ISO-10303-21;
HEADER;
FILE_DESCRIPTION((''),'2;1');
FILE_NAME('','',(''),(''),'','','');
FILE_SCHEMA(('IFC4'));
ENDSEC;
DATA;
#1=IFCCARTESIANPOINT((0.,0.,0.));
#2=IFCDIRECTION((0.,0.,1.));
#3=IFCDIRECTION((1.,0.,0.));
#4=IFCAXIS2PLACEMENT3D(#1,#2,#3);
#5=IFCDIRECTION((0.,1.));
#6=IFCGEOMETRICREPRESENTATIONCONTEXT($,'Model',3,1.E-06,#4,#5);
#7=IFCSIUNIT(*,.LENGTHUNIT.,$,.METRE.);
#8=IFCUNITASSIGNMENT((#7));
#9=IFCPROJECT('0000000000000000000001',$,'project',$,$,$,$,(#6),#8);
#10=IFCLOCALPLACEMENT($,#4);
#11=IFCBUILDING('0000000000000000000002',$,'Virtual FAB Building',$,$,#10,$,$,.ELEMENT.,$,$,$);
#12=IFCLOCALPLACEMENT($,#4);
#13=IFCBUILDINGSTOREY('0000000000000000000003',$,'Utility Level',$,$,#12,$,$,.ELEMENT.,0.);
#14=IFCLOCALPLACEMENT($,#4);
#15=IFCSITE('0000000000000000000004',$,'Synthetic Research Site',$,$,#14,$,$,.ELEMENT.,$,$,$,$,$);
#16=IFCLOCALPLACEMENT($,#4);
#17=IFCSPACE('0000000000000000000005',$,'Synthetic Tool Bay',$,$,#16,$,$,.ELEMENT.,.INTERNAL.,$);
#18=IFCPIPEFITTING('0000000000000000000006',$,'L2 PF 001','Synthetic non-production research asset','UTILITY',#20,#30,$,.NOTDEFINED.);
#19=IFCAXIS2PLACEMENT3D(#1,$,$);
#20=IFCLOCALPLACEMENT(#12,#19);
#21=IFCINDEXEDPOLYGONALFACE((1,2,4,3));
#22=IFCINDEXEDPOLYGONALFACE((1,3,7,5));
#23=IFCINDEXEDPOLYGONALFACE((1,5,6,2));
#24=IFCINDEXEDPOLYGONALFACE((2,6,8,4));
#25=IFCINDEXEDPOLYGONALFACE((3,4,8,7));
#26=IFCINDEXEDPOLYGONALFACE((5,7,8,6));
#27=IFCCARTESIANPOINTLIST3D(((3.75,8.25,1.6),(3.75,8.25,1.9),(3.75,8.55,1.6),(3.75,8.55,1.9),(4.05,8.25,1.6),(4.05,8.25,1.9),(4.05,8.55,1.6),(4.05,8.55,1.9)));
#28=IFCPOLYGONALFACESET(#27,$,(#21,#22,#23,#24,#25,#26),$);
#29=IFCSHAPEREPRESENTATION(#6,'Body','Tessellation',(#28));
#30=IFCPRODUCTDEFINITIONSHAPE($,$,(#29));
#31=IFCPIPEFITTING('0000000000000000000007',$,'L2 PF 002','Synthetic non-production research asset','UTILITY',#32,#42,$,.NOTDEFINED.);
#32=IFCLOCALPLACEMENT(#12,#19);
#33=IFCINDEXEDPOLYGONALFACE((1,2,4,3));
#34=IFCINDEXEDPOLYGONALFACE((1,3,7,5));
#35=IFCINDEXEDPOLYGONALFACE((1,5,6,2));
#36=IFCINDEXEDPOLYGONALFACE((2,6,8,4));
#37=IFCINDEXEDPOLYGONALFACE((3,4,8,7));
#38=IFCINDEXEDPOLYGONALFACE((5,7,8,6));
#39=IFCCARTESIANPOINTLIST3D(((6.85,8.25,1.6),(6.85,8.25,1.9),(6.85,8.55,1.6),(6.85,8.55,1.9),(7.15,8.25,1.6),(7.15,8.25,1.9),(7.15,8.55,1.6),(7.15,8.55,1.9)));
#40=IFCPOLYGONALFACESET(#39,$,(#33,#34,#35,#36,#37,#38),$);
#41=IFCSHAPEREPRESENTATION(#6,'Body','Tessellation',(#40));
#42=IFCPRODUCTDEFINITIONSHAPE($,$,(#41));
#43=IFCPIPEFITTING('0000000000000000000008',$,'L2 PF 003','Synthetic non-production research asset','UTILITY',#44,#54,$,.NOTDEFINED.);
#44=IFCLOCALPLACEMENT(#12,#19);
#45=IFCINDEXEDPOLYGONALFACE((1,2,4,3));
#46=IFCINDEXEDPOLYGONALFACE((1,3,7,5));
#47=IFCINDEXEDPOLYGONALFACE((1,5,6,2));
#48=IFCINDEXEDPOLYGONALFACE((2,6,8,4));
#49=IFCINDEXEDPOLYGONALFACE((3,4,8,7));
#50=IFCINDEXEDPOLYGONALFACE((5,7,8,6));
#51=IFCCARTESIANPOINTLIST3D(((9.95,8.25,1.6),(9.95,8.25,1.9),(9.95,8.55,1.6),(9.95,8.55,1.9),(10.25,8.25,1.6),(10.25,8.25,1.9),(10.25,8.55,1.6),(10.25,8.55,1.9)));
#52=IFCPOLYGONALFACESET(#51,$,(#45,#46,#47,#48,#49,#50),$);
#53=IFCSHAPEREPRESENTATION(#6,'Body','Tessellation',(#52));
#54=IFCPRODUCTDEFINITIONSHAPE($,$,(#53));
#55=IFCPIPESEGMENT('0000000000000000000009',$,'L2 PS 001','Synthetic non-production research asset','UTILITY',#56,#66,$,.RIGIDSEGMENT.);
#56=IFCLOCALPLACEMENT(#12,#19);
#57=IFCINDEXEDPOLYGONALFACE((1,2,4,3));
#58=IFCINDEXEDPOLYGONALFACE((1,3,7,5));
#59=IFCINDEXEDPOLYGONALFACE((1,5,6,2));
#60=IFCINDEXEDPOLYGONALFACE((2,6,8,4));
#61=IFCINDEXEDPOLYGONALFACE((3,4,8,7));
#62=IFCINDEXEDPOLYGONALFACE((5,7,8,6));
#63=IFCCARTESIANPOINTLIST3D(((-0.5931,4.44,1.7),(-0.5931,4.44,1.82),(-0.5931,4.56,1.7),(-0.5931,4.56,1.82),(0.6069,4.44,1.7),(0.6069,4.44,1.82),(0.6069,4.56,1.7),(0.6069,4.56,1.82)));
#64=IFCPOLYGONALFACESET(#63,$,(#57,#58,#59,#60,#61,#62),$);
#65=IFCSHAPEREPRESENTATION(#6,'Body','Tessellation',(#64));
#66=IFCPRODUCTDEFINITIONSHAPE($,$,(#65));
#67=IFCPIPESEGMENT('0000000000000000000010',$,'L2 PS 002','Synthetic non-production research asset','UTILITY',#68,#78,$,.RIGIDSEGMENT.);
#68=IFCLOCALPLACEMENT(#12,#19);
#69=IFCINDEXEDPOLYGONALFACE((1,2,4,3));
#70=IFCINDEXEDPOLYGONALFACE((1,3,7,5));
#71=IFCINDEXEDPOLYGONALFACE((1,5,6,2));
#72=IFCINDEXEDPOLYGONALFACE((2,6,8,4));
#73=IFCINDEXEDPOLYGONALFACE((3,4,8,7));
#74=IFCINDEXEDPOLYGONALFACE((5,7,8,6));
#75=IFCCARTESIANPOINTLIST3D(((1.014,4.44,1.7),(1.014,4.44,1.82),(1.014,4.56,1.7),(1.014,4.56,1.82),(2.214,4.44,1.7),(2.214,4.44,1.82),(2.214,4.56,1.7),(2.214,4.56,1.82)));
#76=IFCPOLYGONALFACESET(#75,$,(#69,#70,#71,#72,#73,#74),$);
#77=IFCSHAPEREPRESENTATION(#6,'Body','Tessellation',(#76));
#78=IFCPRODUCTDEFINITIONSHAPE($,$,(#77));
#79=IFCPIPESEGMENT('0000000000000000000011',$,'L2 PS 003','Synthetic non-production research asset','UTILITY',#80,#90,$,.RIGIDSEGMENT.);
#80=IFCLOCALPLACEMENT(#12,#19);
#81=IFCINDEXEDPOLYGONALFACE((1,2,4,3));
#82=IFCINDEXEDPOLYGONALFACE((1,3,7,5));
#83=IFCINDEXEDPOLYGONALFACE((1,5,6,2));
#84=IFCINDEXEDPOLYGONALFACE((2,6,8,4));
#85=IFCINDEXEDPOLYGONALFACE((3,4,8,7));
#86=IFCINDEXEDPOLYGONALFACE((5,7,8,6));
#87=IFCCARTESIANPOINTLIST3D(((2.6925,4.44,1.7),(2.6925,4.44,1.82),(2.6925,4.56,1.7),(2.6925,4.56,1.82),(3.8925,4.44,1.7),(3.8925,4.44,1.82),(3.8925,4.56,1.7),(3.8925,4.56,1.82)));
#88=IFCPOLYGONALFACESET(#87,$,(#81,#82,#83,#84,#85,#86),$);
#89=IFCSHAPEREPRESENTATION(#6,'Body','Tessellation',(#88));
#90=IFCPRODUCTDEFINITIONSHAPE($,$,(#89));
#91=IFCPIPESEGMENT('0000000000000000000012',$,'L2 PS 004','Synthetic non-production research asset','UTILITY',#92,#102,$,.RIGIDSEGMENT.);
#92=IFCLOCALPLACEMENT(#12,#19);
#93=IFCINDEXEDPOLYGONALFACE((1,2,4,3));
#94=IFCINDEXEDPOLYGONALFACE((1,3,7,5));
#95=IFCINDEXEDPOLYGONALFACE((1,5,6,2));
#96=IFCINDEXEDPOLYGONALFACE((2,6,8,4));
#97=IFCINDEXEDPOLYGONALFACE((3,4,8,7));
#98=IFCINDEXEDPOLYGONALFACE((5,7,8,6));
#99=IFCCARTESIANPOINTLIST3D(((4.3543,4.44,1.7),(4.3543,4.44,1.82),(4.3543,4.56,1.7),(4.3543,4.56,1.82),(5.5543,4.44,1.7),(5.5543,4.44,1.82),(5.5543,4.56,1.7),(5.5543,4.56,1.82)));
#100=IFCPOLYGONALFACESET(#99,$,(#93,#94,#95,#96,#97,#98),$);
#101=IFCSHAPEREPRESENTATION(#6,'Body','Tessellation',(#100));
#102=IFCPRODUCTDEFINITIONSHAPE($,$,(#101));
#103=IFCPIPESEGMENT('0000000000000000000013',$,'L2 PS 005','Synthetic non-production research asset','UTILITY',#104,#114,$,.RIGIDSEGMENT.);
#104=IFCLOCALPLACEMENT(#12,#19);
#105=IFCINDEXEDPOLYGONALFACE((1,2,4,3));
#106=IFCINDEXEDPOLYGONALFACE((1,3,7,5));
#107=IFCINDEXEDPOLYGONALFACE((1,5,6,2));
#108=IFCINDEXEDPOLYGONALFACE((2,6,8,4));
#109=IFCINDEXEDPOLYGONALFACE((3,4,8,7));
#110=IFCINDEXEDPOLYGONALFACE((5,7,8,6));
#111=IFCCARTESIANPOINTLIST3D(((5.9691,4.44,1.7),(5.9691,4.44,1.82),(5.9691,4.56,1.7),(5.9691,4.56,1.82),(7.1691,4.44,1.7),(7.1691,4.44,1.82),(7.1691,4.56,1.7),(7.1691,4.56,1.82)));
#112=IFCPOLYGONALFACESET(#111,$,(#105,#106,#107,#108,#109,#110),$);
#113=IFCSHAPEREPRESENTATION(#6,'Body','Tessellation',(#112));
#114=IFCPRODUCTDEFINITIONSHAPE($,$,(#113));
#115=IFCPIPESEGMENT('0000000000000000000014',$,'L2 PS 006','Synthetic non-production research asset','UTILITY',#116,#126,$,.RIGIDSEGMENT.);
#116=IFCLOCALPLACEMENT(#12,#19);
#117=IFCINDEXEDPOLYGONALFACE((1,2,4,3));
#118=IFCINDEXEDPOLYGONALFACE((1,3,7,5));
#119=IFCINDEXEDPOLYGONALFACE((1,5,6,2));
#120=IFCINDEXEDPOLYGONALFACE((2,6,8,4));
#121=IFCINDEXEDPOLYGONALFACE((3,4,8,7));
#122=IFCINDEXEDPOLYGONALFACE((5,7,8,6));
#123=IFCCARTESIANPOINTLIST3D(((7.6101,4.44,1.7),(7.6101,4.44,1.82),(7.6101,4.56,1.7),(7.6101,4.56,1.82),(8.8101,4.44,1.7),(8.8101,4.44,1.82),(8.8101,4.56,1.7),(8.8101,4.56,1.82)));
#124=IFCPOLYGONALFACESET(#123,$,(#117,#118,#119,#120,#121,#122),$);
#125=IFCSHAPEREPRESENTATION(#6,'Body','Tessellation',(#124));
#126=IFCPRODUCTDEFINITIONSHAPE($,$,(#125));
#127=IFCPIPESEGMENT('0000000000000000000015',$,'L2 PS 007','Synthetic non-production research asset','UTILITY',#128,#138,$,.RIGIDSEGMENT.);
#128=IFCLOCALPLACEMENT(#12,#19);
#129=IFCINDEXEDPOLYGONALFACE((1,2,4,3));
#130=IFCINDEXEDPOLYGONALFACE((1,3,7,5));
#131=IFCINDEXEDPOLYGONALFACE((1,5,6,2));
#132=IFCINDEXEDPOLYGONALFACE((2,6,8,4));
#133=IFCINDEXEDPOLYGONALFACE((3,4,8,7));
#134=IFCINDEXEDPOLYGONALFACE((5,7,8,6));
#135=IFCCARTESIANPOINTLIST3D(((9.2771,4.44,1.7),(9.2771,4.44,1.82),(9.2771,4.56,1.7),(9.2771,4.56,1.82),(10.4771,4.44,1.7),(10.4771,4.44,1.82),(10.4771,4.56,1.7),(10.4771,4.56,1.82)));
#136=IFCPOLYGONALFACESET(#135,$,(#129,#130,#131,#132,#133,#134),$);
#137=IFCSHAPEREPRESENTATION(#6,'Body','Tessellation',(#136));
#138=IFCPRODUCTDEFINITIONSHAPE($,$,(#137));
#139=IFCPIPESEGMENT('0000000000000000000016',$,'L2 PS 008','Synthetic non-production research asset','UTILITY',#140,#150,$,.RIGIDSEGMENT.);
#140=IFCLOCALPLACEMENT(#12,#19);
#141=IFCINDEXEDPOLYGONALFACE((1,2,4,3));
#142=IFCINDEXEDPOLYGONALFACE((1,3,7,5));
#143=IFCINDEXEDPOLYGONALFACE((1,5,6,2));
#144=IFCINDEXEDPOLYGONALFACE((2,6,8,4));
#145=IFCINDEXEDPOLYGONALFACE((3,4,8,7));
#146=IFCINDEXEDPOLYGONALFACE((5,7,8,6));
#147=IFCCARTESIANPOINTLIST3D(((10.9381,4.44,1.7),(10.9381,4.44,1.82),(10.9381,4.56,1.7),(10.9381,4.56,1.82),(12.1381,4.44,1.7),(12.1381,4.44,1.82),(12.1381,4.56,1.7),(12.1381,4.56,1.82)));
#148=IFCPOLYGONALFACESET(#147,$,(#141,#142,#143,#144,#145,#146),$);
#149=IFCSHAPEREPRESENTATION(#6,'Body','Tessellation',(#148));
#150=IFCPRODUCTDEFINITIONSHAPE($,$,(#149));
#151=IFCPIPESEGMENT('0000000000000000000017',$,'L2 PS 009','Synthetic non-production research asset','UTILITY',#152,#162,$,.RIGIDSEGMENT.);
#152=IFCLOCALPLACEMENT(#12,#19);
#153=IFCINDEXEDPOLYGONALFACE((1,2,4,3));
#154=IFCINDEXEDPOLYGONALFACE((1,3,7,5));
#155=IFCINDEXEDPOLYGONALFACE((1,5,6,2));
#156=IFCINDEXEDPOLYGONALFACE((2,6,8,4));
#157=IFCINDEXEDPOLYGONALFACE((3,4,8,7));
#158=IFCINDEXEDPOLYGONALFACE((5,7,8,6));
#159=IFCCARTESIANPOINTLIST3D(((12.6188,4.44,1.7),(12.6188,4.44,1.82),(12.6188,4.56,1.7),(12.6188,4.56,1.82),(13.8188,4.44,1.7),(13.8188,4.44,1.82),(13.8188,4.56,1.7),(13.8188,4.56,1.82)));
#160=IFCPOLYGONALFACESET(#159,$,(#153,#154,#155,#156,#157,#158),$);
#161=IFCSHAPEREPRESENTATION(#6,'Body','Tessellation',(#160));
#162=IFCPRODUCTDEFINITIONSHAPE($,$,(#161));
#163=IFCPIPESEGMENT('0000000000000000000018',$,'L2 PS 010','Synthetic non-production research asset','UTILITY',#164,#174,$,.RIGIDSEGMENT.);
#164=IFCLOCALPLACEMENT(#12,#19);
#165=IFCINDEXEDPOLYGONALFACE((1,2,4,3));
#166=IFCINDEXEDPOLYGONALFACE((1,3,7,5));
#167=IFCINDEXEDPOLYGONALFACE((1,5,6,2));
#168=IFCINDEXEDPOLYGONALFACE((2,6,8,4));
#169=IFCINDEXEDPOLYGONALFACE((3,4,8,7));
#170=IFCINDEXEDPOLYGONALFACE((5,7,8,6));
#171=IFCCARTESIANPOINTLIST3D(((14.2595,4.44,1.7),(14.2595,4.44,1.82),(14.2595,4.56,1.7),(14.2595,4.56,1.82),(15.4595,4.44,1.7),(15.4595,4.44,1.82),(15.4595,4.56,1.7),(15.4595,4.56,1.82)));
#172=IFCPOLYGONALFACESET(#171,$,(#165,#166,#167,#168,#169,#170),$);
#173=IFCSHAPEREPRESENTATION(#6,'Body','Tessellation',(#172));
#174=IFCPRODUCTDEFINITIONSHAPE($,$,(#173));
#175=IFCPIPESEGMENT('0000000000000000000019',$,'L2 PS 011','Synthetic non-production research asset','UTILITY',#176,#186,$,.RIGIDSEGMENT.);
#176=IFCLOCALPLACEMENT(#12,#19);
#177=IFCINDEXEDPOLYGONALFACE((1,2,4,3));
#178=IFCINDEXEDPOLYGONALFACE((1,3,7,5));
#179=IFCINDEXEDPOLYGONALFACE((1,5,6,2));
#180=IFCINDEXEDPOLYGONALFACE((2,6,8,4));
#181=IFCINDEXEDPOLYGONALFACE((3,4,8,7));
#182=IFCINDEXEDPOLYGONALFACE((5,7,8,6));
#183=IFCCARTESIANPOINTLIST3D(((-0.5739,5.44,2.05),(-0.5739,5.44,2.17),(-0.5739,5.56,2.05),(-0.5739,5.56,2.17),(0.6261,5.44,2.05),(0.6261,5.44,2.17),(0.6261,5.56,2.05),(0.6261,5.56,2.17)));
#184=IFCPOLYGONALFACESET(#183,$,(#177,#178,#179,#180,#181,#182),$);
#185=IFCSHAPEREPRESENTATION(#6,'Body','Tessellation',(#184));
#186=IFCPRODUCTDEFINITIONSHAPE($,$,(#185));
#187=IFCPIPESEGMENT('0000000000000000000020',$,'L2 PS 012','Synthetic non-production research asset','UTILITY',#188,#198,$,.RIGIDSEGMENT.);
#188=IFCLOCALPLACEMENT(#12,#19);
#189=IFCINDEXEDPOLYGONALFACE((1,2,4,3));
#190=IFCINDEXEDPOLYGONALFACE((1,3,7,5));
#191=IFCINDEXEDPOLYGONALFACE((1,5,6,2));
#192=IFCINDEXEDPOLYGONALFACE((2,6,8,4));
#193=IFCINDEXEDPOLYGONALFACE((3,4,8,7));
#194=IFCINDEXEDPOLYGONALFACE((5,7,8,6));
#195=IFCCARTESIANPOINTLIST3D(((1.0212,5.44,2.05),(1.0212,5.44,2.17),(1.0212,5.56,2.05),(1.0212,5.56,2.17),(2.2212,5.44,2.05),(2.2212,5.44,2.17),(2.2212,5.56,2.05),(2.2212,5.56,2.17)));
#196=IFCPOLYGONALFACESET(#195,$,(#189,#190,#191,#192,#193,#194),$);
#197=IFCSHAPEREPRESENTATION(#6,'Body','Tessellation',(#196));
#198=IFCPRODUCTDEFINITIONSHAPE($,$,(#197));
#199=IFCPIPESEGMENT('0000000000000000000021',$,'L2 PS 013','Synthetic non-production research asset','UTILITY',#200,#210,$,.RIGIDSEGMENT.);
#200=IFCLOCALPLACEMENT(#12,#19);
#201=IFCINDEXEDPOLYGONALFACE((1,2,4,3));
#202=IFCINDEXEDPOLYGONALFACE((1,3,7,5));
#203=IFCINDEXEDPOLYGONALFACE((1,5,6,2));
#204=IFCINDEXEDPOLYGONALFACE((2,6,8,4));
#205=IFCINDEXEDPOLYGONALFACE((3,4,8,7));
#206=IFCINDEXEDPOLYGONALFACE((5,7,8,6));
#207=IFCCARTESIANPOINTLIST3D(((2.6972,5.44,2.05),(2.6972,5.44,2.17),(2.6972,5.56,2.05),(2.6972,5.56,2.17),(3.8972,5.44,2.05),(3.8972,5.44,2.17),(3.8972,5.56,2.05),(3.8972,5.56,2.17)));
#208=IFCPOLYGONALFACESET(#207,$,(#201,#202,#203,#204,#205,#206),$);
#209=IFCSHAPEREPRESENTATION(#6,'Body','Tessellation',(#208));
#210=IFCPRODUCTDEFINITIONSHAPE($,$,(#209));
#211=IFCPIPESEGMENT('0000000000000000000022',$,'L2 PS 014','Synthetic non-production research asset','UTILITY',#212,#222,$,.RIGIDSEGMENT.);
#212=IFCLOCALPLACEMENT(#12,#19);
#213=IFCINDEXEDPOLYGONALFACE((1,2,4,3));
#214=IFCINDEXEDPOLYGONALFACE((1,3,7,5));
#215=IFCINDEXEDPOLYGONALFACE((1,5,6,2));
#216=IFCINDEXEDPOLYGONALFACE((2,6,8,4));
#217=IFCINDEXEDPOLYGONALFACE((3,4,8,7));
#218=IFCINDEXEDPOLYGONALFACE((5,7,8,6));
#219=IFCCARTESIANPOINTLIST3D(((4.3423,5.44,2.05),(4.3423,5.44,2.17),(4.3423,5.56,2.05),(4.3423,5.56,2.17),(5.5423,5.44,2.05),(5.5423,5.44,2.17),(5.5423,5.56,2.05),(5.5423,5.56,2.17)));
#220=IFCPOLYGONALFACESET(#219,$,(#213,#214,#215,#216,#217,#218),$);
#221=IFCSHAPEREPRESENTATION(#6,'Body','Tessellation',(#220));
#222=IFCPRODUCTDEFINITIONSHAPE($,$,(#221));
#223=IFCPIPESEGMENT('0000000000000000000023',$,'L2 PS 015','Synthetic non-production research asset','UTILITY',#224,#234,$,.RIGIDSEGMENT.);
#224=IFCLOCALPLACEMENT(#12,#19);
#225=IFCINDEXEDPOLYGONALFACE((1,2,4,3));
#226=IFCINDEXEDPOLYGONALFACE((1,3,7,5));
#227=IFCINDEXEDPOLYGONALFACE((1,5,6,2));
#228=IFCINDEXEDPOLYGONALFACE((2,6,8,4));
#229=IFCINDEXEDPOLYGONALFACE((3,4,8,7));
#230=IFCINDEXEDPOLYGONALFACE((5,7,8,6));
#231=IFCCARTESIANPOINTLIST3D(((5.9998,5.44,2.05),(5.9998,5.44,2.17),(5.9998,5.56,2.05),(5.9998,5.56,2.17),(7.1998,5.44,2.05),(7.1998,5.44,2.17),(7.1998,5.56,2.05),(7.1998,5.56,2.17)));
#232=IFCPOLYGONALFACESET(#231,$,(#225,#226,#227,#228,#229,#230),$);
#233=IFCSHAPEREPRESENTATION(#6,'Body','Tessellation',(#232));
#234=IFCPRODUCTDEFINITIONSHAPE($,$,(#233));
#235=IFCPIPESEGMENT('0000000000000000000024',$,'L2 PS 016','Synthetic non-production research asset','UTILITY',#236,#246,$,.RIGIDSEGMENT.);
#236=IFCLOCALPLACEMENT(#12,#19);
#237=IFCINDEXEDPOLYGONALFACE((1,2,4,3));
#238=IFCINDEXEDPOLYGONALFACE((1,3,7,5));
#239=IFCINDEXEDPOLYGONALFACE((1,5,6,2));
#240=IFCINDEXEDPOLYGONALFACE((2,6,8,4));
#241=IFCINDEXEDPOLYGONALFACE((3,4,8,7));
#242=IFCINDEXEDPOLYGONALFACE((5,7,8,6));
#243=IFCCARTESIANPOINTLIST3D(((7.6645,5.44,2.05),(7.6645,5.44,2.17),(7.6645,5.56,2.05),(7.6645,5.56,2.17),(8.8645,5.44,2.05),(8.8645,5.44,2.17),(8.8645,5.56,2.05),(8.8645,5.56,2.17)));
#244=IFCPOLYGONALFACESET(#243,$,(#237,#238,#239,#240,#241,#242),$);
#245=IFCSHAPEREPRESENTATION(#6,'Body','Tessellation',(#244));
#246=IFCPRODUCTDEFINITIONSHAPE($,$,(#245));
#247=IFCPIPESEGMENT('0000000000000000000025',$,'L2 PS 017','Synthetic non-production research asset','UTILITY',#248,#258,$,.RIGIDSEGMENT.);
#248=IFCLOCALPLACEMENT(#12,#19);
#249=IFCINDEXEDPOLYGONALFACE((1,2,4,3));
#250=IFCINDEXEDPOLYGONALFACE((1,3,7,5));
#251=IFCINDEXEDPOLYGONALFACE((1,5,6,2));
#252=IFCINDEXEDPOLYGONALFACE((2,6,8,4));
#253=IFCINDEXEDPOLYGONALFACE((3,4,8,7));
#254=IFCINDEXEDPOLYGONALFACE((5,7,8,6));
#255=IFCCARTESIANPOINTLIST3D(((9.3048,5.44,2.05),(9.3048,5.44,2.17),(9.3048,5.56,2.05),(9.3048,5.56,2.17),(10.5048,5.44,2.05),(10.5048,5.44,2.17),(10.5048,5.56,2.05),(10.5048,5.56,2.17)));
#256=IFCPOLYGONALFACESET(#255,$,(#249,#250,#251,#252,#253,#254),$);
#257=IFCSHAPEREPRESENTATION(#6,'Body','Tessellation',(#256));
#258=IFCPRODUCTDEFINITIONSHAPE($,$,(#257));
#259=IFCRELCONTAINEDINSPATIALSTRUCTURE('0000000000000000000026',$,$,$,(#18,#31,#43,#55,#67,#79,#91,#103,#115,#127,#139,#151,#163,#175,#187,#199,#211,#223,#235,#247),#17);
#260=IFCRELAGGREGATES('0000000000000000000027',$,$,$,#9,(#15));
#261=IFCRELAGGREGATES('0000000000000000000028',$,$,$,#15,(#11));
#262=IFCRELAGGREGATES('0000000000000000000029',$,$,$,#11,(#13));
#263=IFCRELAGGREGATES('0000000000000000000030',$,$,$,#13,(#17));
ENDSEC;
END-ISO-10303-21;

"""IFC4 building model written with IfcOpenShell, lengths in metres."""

from ifc_helpers import new_model, si_unit, direction, frame, origin_with_axes, origin_2d_with_axis, place, context, project, spatial, rectangle, extrude, element, save


model = new_model("IFC4")

# Units and contexts
model_context = context("Model", 3, precision=1e-06, world=origin_with_axes(), true_north=direction((0.0, 1.0)))
ifc_project = project(units=[si_unit("LENGTHUNIT", "METRE")], contexts=[model_context])

# Site, building, storey, space
site_placement = place(None, origin_with_axes())
site = spatial("IfcSite", under=ifc_project, at=site_placement, Name="Synthetic Research Site", CompositionType="ELEMENT")
building_placement = place(None, origin_with_axes())
building = spatial("IfcBuilding", under=site, at=building_placement, Name="Virtual FAB Building", CompositionType="ELEMENT")
storey_placement = place(None, origin_with_axes())
storey = spatial("IfcBuildingStorey", under=building, at=storey_placement, Name="Utility Level", CompositionType="ELEMENT", Elevation=0.0)
space_placement = place(None, origin_with_axes())
space = spatial("IfcSpace", under=storey, at=space_placement, Name="Synthetic Tool Bay", CompositionType="ELEMENT", PredefinedType="INTERNAL")

# Pipe fittings
for number, where, z_axis, x_axis, name in (
    (1, (3.9, 8.4, 1.6), (0.0, 0.0, 1.0), (1.0, 0.0, 0.0), "L2 PF 001"),
    (2, (7.0, 8.4, 1.6), (0.0, 0.0, 1.0), (1.0, 0.0, 0.0), "L2 PF 002"),
    (3, (10.1, 8.4, 1.6), (0.0, 0.0, 1.0), (1.0, 0.0, 0.0), "L2 PF 003"),
):
    element("IfcPipeFitting", number, at=place(None, frame(where, z_axis=z_axis, x_axis=x_axis)), inside=space, Name=name, Description="Synthetic non-production research asset", ObjectType="UTILITY", PredefinedType="NOTDEFINED", context=model_context, shape_type="SweptSolid", body=[
        extrude(rectangle(XDim=0.3, YDim=0.3, at=origin_2d_with_axis()), origin_with_axes(), (0.0, 0.0, 1.0), 0.3),
    ])

# Pipe segments
for number, where, z_axis, x_axis, name in (
    (4, (0.0069, 4.5, 1.7), (0.0, 0.0, 1.0), (1.0, 0.0, 0.0), "L2 PS 001"),
    (5, (1.614, 4.5, 1.7), (0.0, 0.0, 1.0), (1.0, 0.0, 0.0), "L2 PS 002"),
    (6, (3.2925, 4.5, 1.7), (0.0, 0.0, 1.0), (1.0, 0.0, 0.0), "L2 PS 003"),
    (7, (4.9543, 4.5, 1.7), (0.0, 0.0, 1.0), (1.0, 0.0, 0.0), "L2 PS 004"),
    (8, (6.5691, 4.5, 1.7), (0.0, 0.0, 1.0), (1.0, 0.0, 0.0), "L2 PS 005"),
    (9, (8.2101, 4.5, 1.7), (0.0, 0.0, 1.0), (1.0, 0.0, 0.0), "L2 PS 006"),
    (10, (9.8771, 4.5, 1.7), (0.0, 0.0, 1.0), (1.0, 0.0, 0.0), "L2 PS 007"),
    (11, (11.5381, 4.5, 1.7), (0.0, 0.0, 1.0), (1.0, 0.0, 0.0), "L2 PS 008"),
    (12, (13.2188, 4.5, 1.7), (0.0, 0.0, 1.0), (1.0, 0.0, 0.0), "L2 PS 009"),
    (13, (14.8595, 4.5, 1.7), (0.0, 0.0, 1.0), (1.0, 0.0, 0.0), "L2 PS 010"),
    (14, (0.0261, 5.5, 2.05), (0.0, 0.0, 1.0), (1.0, 0.0, 0.0), "L2 PS 011"),
    (15, (1.6212, 5.5, 2.05), (0.0, 0.0, 1.0), (1.0, 0.0, 0.0), "L2 PS 012"),
    (16, (3.2972, 5.5, 2.05), (0.0, 0.0, 1.0), (1.0, 0.0, 0.0), "L2 PS 013"),
    (17, (4.9423, 5.5, 2.05), (0.0, 0.0, 1.0), (1.0, 0.0, 0.0), "L2 PS 014"),
    (18, (6.5998, 5.5, 2.05), (0.0, 0.0, 1.0), (1.0, 0.0, 0.0), "L2 PS 015"),
    (19, (8.2645, 5.5, 2.05), (0.0, 0.0, 1.0), (1.0, 0.0, 0.0), "L2 PS 016"),
    (20, (9.9048, 5.5, 2.05), (0.0, 0.0, 1.0), (1.0, 0.0, 0.0), "L2 PS 017"),
):
    element("IfcPipeSegment", number, at=place(None, frame(where, z_axis=z_axis, x_axis=x_axis)), inside=space, Name=name, Description="Synthetic non-production research asset", ObjectType="UTILITY", PredefinedType="RIGIDSEGMENT", context=model_context, shape_type="SweptSolid", body=[
        extrude(rectangle(XDim=1.2, YDim=0.12, at=origin_2d_with_axis()), origin_with_axes(), (0.0, 0.0, 1.0), 0.12),
    ])

save(model, "model.ifc")
